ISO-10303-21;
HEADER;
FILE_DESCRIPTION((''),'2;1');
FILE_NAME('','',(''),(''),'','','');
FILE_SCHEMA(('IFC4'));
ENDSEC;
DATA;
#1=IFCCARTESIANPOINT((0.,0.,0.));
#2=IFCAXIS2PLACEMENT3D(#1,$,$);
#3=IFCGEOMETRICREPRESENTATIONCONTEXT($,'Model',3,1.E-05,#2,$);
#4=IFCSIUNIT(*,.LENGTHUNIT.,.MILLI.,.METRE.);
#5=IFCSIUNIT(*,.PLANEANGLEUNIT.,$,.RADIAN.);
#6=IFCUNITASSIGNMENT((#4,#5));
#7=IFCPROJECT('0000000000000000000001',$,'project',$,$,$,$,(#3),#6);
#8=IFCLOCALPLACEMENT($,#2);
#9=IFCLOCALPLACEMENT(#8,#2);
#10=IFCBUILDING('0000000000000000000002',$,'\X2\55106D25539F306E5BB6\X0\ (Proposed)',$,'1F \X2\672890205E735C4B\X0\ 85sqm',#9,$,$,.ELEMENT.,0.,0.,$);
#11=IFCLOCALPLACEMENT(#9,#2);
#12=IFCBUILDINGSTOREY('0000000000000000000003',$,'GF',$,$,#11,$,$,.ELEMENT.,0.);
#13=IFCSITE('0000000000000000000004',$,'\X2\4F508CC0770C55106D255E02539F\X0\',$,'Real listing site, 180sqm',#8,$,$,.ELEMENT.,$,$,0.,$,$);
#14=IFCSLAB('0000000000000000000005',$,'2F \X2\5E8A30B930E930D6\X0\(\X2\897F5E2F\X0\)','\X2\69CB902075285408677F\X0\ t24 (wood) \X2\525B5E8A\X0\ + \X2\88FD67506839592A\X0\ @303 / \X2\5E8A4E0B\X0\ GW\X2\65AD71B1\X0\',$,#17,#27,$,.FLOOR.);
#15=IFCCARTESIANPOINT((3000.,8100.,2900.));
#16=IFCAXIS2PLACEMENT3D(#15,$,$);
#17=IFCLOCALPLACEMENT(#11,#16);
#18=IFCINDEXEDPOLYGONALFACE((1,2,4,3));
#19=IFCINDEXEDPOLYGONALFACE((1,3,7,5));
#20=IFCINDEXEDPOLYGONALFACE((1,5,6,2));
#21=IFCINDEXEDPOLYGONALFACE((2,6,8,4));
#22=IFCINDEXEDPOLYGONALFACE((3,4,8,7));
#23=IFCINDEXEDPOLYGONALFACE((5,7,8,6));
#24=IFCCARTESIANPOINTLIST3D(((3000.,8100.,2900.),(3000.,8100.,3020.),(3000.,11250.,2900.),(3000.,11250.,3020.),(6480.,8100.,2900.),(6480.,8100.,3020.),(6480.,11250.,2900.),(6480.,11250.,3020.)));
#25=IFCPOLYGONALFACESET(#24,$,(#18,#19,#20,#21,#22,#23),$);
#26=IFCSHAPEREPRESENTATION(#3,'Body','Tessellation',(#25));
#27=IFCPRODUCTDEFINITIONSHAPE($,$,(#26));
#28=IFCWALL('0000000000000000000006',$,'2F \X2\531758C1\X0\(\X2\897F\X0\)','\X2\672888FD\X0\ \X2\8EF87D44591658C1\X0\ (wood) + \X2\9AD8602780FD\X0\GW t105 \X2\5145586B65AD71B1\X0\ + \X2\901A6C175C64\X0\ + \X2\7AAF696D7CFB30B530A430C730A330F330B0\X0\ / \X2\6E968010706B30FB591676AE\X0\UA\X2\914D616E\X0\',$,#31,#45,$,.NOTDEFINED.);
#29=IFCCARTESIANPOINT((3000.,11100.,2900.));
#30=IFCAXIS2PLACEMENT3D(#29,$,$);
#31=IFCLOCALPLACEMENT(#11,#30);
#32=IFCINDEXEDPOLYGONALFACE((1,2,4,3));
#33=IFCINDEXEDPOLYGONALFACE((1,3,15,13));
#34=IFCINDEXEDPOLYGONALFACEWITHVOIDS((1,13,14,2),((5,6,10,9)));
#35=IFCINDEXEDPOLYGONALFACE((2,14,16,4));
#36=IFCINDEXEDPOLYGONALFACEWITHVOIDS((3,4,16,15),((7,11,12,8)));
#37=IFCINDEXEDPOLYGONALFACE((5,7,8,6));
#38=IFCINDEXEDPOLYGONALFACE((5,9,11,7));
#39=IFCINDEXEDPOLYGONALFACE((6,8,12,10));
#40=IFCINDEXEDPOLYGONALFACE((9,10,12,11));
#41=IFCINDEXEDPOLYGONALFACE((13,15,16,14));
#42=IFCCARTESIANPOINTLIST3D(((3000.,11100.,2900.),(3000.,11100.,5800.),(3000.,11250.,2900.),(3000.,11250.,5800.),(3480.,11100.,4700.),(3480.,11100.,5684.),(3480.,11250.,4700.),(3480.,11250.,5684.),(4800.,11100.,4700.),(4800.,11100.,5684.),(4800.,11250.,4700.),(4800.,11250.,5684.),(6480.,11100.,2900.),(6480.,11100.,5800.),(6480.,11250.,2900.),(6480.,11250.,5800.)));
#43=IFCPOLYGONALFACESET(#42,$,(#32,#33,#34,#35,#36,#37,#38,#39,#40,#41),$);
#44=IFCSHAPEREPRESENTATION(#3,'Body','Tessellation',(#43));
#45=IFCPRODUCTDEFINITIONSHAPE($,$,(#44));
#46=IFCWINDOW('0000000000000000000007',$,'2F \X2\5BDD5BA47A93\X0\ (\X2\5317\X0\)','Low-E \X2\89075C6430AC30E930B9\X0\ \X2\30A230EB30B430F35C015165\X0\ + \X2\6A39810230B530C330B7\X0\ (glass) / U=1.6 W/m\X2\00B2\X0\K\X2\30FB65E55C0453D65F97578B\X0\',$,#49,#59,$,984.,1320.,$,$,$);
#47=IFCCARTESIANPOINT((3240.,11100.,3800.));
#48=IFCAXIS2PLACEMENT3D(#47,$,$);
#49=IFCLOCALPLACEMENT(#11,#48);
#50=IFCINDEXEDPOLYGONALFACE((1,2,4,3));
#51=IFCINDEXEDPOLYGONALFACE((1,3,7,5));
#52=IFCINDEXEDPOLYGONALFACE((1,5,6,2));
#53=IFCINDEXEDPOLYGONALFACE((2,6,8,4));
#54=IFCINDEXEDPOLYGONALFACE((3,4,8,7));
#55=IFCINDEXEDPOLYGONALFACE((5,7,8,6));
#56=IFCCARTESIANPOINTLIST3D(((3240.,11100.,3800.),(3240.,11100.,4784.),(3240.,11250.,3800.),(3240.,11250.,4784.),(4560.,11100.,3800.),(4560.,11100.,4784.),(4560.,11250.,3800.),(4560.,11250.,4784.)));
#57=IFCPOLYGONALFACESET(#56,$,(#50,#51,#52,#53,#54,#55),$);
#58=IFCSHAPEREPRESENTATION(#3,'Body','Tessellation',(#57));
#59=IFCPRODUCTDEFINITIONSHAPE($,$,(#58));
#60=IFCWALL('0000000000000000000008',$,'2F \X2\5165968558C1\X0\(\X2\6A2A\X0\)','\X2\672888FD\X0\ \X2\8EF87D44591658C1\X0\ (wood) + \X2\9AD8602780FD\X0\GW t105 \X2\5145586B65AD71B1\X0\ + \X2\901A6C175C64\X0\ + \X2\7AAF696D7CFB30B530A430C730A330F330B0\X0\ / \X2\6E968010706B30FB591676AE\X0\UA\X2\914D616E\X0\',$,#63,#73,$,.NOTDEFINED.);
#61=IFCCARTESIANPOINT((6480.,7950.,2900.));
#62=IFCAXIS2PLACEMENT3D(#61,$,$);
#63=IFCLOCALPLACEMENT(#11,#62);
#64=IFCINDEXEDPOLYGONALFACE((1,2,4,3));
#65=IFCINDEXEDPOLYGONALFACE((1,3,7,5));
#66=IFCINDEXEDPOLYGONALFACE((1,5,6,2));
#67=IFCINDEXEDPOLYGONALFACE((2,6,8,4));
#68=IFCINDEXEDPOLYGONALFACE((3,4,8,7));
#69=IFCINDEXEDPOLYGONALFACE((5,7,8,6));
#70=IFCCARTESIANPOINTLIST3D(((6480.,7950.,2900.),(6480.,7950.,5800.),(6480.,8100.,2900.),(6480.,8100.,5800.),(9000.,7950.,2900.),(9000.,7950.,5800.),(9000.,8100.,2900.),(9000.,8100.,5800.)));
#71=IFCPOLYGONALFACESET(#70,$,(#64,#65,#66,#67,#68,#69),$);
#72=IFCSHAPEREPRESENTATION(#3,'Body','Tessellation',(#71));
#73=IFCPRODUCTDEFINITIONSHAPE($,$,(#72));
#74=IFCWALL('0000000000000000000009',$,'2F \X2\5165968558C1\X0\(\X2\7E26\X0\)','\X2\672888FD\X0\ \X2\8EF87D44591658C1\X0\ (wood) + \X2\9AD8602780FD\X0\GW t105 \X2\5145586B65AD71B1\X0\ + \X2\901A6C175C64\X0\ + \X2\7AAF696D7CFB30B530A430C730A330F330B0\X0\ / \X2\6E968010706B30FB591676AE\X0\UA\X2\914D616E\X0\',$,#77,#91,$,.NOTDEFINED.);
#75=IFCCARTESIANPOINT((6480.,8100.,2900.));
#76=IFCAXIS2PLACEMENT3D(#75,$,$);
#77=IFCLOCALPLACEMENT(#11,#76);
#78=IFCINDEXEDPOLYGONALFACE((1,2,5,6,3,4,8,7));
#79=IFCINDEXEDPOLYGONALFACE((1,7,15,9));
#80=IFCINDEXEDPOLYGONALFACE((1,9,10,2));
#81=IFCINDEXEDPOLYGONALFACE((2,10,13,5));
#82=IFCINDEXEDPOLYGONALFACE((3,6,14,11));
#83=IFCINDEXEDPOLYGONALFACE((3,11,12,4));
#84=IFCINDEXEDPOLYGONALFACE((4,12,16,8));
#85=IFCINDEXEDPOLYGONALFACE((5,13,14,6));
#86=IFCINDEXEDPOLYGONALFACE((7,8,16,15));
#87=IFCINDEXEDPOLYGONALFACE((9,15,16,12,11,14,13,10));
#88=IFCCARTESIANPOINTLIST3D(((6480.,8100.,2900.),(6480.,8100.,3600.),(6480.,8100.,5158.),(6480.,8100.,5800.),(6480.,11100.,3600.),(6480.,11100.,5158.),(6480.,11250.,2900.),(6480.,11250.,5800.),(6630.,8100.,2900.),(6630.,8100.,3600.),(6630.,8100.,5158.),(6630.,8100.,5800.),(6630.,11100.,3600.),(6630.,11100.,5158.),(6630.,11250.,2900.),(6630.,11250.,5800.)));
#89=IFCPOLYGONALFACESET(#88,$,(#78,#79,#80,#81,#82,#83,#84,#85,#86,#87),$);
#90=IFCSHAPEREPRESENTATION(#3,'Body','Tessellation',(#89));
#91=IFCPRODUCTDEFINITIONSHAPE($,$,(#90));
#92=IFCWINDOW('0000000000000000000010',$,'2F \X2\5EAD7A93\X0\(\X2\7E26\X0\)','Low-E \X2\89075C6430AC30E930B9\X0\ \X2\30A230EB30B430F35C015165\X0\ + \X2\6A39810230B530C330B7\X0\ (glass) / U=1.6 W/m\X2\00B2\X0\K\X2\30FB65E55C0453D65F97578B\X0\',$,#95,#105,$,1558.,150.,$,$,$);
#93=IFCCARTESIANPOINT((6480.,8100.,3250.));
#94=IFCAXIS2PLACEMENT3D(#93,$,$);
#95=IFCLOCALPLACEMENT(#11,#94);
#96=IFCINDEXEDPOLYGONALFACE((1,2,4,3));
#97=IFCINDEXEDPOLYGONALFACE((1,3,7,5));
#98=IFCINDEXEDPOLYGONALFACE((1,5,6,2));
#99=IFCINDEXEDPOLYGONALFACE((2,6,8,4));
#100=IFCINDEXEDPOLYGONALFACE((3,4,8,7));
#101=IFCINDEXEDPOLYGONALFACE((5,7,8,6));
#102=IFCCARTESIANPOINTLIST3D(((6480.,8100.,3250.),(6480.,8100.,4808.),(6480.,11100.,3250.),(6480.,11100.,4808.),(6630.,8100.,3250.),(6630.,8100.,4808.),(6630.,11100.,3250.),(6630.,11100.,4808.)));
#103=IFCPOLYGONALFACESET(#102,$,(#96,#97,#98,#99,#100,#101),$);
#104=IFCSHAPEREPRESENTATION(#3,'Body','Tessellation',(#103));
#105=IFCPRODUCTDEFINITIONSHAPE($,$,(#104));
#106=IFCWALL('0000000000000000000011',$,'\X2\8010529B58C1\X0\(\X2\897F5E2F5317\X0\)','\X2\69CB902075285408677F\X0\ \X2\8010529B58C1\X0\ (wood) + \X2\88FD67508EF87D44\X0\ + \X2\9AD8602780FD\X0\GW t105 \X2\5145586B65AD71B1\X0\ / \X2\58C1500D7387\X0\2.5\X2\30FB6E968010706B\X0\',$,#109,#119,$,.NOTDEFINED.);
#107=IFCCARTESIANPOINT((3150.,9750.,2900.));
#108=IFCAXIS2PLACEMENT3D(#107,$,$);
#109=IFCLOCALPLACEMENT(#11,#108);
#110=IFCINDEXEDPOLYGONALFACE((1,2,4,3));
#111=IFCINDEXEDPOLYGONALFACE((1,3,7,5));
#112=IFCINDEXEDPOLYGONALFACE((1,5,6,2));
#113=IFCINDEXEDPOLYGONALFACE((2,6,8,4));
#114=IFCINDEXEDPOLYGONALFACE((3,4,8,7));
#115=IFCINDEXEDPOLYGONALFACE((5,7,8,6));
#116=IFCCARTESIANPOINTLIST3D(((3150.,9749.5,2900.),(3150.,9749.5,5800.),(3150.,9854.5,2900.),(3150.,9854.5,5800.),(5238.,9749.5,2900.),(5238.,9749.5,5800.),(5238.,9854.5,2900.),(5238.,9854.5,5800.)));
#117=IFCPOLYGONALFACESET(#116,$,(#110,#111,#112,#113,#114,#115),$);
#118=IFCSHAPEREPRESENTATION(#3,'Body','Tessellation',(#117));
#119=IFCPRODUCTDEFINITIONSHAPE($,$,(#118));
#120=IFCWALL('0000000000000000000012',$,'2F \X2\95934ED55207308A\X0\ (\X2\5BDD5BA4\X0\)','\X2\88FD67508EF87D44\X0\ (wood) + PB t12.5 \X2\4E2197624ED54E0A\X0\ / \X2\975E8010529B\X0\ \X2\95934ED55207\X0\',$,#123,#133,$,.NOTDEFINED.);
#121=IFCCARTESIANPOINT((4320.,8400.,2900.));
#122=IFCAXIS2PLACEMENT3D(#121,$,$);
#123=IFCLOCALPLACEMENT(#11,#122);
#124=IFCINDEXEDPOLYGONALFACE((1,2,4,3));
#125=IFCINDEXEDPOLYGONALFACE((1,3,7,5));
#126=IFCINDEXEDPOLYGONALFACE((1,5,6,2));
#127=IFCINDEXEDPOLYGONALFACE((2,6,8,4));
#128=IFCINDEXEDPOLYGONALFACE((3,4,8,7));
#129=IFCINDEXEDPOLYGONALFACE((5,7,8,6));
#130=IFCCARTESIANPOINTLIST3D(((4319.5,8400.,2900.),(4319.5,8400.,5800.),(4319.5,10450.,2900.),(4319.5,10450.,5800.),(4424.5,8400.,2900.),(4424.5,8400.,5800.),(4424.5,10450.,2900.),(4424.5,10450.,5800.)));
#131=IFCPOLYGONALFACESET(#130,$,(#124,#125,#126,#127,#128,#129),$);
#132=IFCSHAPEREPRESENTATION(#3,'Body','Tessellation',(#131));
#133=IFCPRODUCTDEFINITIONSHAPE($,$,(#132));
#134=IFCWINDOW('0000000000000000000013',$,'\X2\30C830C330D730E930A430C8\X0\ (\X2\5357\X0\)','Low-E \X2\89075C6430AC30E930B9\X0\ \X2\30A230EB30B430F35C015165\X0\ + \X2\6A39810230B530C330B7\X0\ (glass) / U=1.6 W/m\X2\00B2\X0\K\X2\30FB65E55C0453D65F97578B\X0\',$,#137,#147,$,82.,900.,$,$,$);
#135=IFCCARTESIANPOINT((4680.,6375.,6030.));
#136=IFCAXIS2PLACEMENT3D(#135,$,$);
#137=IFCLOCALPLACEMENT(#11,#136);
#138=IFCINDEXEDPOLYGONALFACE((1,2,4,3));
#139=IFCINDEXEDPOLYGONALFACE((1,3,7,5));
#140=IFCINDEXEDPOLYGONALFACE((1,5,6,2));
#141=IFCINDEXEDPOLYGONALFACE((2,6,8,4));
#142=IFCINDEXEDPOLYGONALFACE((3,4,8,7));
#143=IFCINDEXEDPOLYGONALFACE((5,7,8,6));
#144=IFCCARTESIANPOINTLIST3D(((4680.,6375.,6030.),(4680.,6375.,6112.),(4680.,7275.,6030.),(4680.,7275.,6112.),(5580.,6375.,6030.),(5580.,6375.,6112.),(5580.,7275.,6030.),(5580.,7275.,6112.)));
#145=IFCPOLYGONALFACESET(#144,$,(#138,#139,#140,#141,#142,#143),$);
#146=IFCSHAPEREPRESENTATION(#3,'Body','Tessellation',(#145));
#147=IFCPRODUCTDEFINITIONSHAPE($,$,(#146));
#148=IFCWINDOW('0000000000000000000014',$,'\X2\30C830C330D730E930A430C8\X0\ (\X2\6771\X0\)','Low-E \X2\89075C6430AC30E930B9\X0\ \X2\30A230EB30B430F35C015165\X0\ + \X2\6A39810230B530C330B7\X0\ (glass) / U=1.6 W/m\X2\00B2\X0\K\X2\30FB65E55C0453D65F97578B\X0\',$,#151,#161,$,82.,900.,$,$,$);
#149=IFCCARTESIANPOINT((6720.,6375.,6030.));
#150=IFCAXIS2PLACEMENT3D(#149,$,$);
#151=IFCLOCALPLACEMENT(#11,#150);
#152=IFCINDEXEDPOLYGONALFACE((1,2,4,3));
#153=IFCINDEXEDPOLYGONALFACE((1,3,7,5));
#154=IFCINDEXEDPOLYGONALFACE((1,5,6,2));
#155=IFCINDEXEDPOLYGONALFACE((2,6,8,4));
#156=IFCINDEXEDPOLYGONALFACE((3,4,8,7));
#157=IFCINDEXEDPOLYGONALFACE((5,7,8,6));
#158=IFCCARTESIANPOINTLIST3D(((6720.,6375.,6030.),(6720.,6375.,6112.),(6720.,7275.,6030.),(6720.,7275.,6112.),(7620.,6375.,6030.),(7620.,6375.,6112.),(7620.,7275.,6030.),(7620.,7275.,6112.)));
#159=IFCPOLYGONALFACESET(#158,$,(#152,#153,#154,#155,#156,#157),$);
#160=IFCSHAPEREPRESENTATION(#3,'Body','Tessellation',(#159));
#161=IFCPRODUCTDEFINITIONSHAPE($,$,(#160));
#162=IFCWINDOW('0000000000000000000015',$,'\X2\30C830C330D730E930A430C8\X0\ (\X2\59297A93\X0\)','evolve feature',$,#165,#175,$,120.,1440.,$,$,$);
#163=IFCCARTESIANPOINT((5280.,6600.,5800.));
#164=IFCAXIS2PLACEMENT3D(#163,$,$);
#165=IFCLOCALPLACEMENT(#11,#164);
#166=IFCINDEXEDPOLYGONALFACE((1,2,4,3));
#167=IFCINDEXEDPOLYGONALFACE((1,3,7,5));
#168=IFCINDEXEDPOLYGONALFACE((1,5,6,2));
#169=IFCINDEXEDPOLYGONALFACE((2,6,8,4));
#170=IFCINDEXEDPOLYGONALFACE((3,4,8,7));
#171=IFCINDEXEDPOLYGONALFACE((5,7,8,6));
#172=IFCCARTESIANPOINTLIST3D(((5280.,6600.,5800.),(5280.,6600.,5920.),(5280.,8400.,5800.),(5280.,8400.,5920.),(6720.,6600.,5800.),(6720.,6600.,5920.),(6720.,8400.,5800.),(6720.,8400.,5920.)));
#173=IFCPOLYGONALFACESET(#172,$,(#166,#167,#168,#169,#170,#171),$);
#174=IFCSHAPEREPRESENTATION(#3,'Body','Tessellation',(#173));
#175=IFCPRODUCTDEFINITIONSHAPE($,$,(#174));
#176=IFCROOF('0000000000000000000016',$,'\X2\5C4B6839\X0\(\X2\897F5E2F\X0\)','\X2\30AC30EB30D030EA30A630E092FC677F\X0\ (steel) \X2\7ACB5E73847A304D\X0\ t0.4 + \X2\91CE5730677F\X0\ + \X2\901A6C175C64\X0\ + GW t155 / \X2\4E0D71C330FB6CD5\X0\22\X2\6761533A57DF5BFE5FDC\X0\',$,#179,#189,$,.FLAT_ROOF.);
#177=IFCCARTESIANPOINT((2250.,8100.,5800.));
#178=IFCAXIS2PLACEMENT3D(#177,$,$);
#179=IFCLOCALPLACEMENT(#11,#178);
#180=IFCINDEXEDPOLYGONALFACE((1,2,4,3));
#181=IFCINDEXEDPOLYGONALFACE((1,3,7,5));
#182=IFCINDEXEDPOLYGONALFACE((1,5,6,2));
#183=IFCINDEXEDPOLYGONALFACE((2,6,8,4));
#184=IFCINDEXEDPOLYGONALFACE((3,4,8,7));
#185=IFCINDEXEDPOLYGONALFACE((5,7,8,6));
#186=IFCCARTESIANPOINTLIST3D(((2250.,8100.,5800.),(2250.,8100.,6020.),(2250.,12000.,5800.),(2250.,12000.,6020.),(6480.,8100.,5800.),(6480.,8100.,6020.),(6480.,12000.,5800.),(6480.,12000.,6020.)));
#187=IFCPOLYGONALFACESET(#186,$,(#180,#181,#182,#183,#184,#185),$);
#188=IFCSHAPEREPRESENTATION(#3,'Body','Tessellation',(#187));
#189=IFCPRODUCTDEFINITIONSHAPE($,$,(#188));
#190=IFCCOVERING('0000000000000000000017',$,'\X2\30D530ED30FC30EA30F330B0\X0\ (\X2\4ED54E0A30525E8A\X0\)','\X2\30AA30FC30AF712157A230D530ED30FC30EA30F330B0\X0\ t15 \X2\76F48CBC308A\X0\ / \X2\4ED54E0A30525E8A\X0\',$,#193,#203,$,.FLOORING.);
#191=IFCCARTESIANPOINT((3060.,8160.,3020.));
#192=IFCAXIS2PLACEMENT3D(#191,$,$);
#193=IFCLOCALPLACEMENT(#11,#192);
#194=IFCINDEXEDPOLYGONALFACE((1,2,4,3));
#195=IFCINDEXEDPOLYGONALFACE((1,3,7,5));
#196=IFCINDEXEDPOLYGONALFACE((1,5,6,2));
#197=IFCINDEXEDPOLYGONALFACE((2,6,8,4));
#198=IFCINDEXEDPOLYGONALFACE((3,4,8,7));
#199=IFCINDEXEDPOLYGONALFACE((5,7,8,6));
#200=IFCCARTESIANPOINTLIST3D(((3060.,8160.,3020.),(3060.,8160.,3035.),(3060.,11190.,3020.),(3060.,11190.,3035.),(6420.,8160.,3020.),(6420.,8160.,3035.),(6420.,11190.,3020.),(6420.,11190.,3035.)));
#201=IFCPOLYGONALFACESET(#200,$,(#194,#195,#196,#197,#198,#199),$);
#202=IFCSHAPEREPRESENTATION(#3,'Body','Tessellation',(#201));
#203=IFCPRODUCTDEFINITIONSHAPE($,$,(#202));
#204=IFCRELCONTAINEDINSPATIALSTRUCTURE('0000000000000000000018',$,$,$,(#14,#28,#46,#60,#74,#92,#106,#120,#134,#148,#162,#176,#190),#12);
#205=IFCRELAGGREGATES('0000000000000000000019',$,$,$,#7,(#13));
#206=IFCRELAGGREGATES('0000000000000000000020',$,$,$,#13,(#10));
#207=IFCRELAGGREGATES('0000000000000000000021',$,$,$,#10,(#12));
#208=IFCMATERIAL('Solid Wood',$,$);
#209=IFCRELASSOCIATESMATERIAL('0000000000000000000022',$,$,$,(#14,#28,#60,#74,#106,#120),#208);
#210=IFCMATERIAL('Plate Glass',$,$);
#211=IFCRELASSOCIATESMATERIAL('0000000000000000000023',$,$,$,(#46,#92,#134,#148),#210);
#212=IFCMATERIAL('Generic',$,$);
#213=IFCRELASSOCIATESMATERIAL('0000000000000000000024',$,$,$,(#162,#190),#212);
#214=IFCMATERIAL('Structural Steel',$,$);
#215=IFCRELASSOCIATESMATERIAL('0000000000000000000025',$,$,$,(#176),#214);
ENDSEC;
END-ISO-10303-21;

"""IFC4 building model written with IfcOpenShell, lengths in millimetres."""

from ifc_helpers import new_model, si_unit, frame, frame_2d, origin, place, context, project, spatial, rectangle, extrude, material, element, fill, save


model = new_model("IFC4")

# Units and contexts
model_context = context("Model", 3, precision=1e-05, world=origin())
ifc_project = project(units=[si_unit("LENGTHUNIT", "METRE", prefix="MILLI"), si_unit("PLANEANGLEUNIT", "RADIAN")], contexts=[model_context])

# Site, building, storey
site_placement = place(None, origin())
site = spatial("IfcSite", under=ifc_project, at=site_placement, Name="佐賀県唐津市原", ObjectType="Real listing site, 180sqm", CompositionType="ELEMENT", RefElevation=0.0)
building_placement = place(site_placement, origin())
building = spatial("IfcBuilding", under=site, at=building_placement, Name="唐津原の家 (Proposed)", ObjectType="1F 木造平屋 85sqm", CompositionType="ELEMENT", ElevationOfRefHeight=0.0, ElevationOfTerrain=0.0)
storey_placement = place(building_placement, origin())
storey = spatial("IfcBuildingStorey", under=building, at=storey_placement, Name="GF", CompositionType="ELEMENT", Elevation=0.0)

# Slab
ifc_material_1 = material(Name="Solid Wood")
slab_placement = place(storey_placement, frame((3000.0, 8100.0, 2900.0)))
element("IfcSlab", 1, at=slab_placement, inside=storey, material=ifc_material_1, Name="2F 床スラブ(西帯)", Description="構造用合板 t24 (wood) 剛床 + 製材根太 @303 / 床下 GW断熱", PredefinedType="FLOOR", context=model_context, shape_type="SweptSolid", body=[
    extrude(rectangle(XDim=3480.0, YDim=3150.0, at=frame_2d((1740.0, 1575.0))), frame((3000.0, 8100.0, 2900.0)), (0.0, 0.0, 1.0), 120.0),
])

# Wall, opening, window
wall_1_placement = place(storey_placement, frame((3000.0, 11100.0, 2900.0)))
wall_1 = element("IfcWall", 2, at=wall_1_placement, inside=storey, material=ifc_material_1, Name="2F 北壁(西)", Description="木製 軸組外壁 (wood) + 高性能GW t105 充填断熱 + 通気層 + 窯業系サイディング / 準耐火・外皮UA配慮", PredefinedType="NOTDEFINED", context=model_context, shape_type="SweptSolid", body=[
    extrude(rectangle(XDim=3480.0, YDim=150.0, at=frame_2d((1740.0, 75.0))), frame((3000.0, 11100.0, 2900.0)), (0.0, 0.0, 1.0), 2900.0),
])
opening_1_placement = place(storey_placement, frame((3240.0, 11100.0, 3800.0)))
opening_1 = element("IfcOpeningElement", 3, at=opening_1_placement, cuts=wall_1, PredefinedType="NOTDEFINED", context=model_context, shape_type="SweptSolid", body=[
    extrude(rectangle(XDim=1320.0, YDim=150.0, at=frame_2d((660.0, 75.0))), frame((3240.0, 11100.0, 3800.0)), (0.0, 0.0, 1.0), 984.0),
])
ifc_material_2 = material(Name="Plate Glass")
window_1_placement = place(storey_placement, frame((3240.0, 11100.0, 3800.0)))
window_1 = element("IfcWindow", 4, at=window_1_placement, inside=storey, material=ifc_material_2, Name="2F 寝室窓 (北)", Description="Low-E 複層ガラス アルゴン封入 + 樹脂サッシ (glass) / U=1.6 W/m²K・日射取得型", OverallHeight=984.0, OverallWidth=1320.0, context=model_context, shape_type="SweptSolid", body=[
    extrude(rectangle(XDim=1320.0, YDim=150.0, at=frame_2d((660.0, 75.0))), frame((3240.0, 11100.0, 3800.0)), (0.0, 0.0, 1.0), 984.0),
])
fill(opening_1, window_1)

# Wall
wall_2_placement = place(storey_placement, frame((6480.0, 7950.0, 2900.0)))
element("IfcWall", 5, at=wall_2_placement, inside=storey, material=ifc_material_1, Name="2F 入隅壁(横)", Description="木製 軸組外壁 (wood) + 高性能GW t105 充填断熱 + 通気層 + 窯業系サイディング / 準耐火・外皮UA配慮", PredefinedType="NOTDEFINED", context=model_context, shape_type="SweptSolid", body=[
    extrude(rectangle(XDim=2520.0, YDim=150.0, at=frame_2d((1260.0, 75.0))), frame((6480.0, 7950.0, 2900.0)), (0.0, 0.0, 1.0), 2900.0),
])

# Wall, opening, window
wall_3_placement = place(storey_placement, frame((6480.0, 8100.0, 2900.0)))
wall_3 = element("IfcWall", 6, at=wall_3_placement, inside=storey, material=ifc_material_1, Name="2F 入隅壁(縦)", Description="木製 軸組外壁 (wood) + 高性能GW t105 充填断熱 + 通気層 + 窯業系サイディング / 準耐火・外皮UA配慮", PredefinedType="NOTDEFINED", context=model_context, shape_type="SweptSolid", body=[
    extrude(rectangle(XDim=150.0, YDim=3150.0, at=frame_2d((75.0, 1575.0))), frame((6480.0, 8100.0, 2900.0)), (0.0, 0.0, 1.0), 2900.0),
])
opening_2_placement = place(storey_placement, frame((6480.0, 8100.0, 3250.0)))
opening_2 = element("IfcOpeningElement", 7, at=opening_2_placement, cuts=wall_3, PredefinedType="NOTDEFINED", context=model_context, shape_type="SweptSolid", body=[
    extrude(rectangle(XDim=150.0, YDim=3000.0, at=frame_2d((75.0, 1500.0))), frame((6480.0, 8100.0, 3250.0)), (0.0, 0.0, 1.0), 1558.0),
])
window_2_placement = place(storey_placement, frame((6480.0, 8100.0, 3250.0)))
window_2 = element("IfcWindow", 8, at=window_2_placement, inside=storey, material=ifc_material_2, Name="2F 庭窓(縦)", Description="Low-E 複層ガラス アルゴン封入 + 樹脂サッシ (glass) / U=1.6 W/m²K・日射取得型", OverallHeight=1558.0, OverallWidth=150.0, context=model_context, shape_type="SweptSolid", body=[
    extrude(rectangle(XDim=150.0, YDim=3000.0, at=frame_2d((75.0, 1500.0))), frame((6480.0, 8100.0, 3250.0)), (0.0, 0.0, 1.0), 1558.0),
])
fill(opening_2, window_2)

# Walls
wall_4_placement = place(storey_placement, frame((3150.0, 9750.0, 2900.0)))
element("IfcWall", 9, at=wall_4_placement, inside=storey, material=ifc_material_1, Name="耐力壁(西帯北)", Description="構造用合板 耐力壁 (wood) + 製材軸組 + 高性能GW t105 充填断熱 / 壁倍率2.5・準耐火", PredefinedType="NOTDEFINED", context=model_context, shape_type="SweptSolid", body=[
    extrude(rectangle(XDim=2088.0, YDim=105.0, at=frame_2d((1044.0, 52.0))), frame((3150.0, 9750.0, 2900.0)), (0.0, 0.0, 1.0), 2900.0),
])
wall_5_placement = place(storey_placement, frame((4320.0, 8400.0, 2900.0)))
element("IfcWall", 10, at=wall_5_placement, inside=storey, material=ifc_material_1, Name="2F 間仕切り (寝室)", Description="製材軸組 (wood) + PB t12.5 両面仕上 / 非耐力 間仕切", PredefinedType="NOTDEFINED", context=model_context, shape_type="SweptSolid", body=[
    extrude(rectangle(XDim=105.0, YDim=2050.0, at=frame_2d((52.0, 1025.0))), frame((4320.0, 8400.0, 2900.0)), (0.0, 0.0, 1.0), 2900.0),
])

# Windows
window_3_placement = place(storey_placement, frame((4680.0, 6375.0, 6030.0)))
element("IfcWindow", 11, at=window_3_placement, inside=storey, material=ifc_material_2, Name="トップライト (南)", Description="Low-E 複層ガラス アルゴン封入 + 樹脂サッシ (glass) / U=1.6 W/m²K・日射取得型", OverallHeight=82.0, OverallWidth=900.0, context=model_context, shape_type="SweptSolid", body=[
    extrude(rectangle(XDim=900.0, YDim=900.0, at=frame_2d((450.0, 450.0))), frame((4680.0, 6375.0, 6030.0)), (0.0, 0.0, 1.0), 82.0),
])
window_4_placement = place(storey_placement, frame((6720.0, 6375.0, 6030.0)))
element("IfcWindow", 12, at=window_4_placement, inside=storey, material=ifc_material_2, Name="トップライト (東)", Description="Low-E 複層ガラス アルゴン封入 + 樹脂サッシ (glass) / U=1.6 W/m²K・日射取得型", OverallHeight=82.0, OverallWidth=900.0, context=model_context, shape_type="SweptSolid", body=[
    extrude(rectangle(XDim=900.0, YDim=900.0, at=frame_2d((450.0, 450.0))), frame((6720.0, 6375.0, 6030.0)), (0.0, 0.0, 1.0), 82.0),
])
ifc_material_3 = material(Name="Generic")
window_5_placement = place(storey_placement, frame((5280.0, 6600.0, 5800.0)))
element("IfcWindow", 13, at=window_5_placement, inside=storey, material=ifc_material_3, Name="トップライト (天窓)", Description="evolve feature", OverallHeight=120.0, OverallWidth=1440.0, context=model_context, shape_type="SweptSolid", body=[
    extrude(rectangle(XDim=1440.0, YDim=1800.0, at=frame_2d((720.0, 900.0))), frame((5280.0, 6600.0, 5800.0)), (0.0, 0.0, 1.0), 120.0),
])

# Roof
ifc_material_4 = material(Name="Structural Steel")
for number, where, name in (
    (14, (2250.0, 8100.0, 5800.0), "屋根(西帯)"),
):
    element("IfcRoof", number, at=place(storey_placement, frame(where)), inside=storey, material=ifc_material_4, Name=name, Description="ガルバリウム鋼板 (steel) 立平葺き t0.4 + 野地板 + 通気層 + GW t155 / 不燃・法22条区域対応", PredefinedType="FLAT_ROOF", context=model_context, shape_type="SweptSolid", body=[
        extrude(rectangle(XDim=4230.0, YDim=3900.0, at=frame_2d((2115.0, 1950.0))), frame((2250.0, 8100.0, 5800.0)), (0.0, 0.0, 1.0), 220.0),
    ])

# Covering
covering_placement = place(storey_placement, frame((3060.0, 8160.0, 3020.0)))
element("IfcCovering", 15, at=covering_placement, inside=storey, material=ifc_material_3, Name="フローリング (仕上げ床)", Description="オーク無垢フローリング t15 直貼り / 仕上げ床", PredefinedType="FLOORING", context=model_context, shape_type="SweptSolid", body=[
    extrude(rectangle(XDim=3360.0, YDim=3030.0, at=frame_2d((1680.0, 1515.0))), frame((3060.0, 8160.0, 3020.0)), (0.0, 0.0, 1.0), 15.0),
])

save(model, "model.ifc")
